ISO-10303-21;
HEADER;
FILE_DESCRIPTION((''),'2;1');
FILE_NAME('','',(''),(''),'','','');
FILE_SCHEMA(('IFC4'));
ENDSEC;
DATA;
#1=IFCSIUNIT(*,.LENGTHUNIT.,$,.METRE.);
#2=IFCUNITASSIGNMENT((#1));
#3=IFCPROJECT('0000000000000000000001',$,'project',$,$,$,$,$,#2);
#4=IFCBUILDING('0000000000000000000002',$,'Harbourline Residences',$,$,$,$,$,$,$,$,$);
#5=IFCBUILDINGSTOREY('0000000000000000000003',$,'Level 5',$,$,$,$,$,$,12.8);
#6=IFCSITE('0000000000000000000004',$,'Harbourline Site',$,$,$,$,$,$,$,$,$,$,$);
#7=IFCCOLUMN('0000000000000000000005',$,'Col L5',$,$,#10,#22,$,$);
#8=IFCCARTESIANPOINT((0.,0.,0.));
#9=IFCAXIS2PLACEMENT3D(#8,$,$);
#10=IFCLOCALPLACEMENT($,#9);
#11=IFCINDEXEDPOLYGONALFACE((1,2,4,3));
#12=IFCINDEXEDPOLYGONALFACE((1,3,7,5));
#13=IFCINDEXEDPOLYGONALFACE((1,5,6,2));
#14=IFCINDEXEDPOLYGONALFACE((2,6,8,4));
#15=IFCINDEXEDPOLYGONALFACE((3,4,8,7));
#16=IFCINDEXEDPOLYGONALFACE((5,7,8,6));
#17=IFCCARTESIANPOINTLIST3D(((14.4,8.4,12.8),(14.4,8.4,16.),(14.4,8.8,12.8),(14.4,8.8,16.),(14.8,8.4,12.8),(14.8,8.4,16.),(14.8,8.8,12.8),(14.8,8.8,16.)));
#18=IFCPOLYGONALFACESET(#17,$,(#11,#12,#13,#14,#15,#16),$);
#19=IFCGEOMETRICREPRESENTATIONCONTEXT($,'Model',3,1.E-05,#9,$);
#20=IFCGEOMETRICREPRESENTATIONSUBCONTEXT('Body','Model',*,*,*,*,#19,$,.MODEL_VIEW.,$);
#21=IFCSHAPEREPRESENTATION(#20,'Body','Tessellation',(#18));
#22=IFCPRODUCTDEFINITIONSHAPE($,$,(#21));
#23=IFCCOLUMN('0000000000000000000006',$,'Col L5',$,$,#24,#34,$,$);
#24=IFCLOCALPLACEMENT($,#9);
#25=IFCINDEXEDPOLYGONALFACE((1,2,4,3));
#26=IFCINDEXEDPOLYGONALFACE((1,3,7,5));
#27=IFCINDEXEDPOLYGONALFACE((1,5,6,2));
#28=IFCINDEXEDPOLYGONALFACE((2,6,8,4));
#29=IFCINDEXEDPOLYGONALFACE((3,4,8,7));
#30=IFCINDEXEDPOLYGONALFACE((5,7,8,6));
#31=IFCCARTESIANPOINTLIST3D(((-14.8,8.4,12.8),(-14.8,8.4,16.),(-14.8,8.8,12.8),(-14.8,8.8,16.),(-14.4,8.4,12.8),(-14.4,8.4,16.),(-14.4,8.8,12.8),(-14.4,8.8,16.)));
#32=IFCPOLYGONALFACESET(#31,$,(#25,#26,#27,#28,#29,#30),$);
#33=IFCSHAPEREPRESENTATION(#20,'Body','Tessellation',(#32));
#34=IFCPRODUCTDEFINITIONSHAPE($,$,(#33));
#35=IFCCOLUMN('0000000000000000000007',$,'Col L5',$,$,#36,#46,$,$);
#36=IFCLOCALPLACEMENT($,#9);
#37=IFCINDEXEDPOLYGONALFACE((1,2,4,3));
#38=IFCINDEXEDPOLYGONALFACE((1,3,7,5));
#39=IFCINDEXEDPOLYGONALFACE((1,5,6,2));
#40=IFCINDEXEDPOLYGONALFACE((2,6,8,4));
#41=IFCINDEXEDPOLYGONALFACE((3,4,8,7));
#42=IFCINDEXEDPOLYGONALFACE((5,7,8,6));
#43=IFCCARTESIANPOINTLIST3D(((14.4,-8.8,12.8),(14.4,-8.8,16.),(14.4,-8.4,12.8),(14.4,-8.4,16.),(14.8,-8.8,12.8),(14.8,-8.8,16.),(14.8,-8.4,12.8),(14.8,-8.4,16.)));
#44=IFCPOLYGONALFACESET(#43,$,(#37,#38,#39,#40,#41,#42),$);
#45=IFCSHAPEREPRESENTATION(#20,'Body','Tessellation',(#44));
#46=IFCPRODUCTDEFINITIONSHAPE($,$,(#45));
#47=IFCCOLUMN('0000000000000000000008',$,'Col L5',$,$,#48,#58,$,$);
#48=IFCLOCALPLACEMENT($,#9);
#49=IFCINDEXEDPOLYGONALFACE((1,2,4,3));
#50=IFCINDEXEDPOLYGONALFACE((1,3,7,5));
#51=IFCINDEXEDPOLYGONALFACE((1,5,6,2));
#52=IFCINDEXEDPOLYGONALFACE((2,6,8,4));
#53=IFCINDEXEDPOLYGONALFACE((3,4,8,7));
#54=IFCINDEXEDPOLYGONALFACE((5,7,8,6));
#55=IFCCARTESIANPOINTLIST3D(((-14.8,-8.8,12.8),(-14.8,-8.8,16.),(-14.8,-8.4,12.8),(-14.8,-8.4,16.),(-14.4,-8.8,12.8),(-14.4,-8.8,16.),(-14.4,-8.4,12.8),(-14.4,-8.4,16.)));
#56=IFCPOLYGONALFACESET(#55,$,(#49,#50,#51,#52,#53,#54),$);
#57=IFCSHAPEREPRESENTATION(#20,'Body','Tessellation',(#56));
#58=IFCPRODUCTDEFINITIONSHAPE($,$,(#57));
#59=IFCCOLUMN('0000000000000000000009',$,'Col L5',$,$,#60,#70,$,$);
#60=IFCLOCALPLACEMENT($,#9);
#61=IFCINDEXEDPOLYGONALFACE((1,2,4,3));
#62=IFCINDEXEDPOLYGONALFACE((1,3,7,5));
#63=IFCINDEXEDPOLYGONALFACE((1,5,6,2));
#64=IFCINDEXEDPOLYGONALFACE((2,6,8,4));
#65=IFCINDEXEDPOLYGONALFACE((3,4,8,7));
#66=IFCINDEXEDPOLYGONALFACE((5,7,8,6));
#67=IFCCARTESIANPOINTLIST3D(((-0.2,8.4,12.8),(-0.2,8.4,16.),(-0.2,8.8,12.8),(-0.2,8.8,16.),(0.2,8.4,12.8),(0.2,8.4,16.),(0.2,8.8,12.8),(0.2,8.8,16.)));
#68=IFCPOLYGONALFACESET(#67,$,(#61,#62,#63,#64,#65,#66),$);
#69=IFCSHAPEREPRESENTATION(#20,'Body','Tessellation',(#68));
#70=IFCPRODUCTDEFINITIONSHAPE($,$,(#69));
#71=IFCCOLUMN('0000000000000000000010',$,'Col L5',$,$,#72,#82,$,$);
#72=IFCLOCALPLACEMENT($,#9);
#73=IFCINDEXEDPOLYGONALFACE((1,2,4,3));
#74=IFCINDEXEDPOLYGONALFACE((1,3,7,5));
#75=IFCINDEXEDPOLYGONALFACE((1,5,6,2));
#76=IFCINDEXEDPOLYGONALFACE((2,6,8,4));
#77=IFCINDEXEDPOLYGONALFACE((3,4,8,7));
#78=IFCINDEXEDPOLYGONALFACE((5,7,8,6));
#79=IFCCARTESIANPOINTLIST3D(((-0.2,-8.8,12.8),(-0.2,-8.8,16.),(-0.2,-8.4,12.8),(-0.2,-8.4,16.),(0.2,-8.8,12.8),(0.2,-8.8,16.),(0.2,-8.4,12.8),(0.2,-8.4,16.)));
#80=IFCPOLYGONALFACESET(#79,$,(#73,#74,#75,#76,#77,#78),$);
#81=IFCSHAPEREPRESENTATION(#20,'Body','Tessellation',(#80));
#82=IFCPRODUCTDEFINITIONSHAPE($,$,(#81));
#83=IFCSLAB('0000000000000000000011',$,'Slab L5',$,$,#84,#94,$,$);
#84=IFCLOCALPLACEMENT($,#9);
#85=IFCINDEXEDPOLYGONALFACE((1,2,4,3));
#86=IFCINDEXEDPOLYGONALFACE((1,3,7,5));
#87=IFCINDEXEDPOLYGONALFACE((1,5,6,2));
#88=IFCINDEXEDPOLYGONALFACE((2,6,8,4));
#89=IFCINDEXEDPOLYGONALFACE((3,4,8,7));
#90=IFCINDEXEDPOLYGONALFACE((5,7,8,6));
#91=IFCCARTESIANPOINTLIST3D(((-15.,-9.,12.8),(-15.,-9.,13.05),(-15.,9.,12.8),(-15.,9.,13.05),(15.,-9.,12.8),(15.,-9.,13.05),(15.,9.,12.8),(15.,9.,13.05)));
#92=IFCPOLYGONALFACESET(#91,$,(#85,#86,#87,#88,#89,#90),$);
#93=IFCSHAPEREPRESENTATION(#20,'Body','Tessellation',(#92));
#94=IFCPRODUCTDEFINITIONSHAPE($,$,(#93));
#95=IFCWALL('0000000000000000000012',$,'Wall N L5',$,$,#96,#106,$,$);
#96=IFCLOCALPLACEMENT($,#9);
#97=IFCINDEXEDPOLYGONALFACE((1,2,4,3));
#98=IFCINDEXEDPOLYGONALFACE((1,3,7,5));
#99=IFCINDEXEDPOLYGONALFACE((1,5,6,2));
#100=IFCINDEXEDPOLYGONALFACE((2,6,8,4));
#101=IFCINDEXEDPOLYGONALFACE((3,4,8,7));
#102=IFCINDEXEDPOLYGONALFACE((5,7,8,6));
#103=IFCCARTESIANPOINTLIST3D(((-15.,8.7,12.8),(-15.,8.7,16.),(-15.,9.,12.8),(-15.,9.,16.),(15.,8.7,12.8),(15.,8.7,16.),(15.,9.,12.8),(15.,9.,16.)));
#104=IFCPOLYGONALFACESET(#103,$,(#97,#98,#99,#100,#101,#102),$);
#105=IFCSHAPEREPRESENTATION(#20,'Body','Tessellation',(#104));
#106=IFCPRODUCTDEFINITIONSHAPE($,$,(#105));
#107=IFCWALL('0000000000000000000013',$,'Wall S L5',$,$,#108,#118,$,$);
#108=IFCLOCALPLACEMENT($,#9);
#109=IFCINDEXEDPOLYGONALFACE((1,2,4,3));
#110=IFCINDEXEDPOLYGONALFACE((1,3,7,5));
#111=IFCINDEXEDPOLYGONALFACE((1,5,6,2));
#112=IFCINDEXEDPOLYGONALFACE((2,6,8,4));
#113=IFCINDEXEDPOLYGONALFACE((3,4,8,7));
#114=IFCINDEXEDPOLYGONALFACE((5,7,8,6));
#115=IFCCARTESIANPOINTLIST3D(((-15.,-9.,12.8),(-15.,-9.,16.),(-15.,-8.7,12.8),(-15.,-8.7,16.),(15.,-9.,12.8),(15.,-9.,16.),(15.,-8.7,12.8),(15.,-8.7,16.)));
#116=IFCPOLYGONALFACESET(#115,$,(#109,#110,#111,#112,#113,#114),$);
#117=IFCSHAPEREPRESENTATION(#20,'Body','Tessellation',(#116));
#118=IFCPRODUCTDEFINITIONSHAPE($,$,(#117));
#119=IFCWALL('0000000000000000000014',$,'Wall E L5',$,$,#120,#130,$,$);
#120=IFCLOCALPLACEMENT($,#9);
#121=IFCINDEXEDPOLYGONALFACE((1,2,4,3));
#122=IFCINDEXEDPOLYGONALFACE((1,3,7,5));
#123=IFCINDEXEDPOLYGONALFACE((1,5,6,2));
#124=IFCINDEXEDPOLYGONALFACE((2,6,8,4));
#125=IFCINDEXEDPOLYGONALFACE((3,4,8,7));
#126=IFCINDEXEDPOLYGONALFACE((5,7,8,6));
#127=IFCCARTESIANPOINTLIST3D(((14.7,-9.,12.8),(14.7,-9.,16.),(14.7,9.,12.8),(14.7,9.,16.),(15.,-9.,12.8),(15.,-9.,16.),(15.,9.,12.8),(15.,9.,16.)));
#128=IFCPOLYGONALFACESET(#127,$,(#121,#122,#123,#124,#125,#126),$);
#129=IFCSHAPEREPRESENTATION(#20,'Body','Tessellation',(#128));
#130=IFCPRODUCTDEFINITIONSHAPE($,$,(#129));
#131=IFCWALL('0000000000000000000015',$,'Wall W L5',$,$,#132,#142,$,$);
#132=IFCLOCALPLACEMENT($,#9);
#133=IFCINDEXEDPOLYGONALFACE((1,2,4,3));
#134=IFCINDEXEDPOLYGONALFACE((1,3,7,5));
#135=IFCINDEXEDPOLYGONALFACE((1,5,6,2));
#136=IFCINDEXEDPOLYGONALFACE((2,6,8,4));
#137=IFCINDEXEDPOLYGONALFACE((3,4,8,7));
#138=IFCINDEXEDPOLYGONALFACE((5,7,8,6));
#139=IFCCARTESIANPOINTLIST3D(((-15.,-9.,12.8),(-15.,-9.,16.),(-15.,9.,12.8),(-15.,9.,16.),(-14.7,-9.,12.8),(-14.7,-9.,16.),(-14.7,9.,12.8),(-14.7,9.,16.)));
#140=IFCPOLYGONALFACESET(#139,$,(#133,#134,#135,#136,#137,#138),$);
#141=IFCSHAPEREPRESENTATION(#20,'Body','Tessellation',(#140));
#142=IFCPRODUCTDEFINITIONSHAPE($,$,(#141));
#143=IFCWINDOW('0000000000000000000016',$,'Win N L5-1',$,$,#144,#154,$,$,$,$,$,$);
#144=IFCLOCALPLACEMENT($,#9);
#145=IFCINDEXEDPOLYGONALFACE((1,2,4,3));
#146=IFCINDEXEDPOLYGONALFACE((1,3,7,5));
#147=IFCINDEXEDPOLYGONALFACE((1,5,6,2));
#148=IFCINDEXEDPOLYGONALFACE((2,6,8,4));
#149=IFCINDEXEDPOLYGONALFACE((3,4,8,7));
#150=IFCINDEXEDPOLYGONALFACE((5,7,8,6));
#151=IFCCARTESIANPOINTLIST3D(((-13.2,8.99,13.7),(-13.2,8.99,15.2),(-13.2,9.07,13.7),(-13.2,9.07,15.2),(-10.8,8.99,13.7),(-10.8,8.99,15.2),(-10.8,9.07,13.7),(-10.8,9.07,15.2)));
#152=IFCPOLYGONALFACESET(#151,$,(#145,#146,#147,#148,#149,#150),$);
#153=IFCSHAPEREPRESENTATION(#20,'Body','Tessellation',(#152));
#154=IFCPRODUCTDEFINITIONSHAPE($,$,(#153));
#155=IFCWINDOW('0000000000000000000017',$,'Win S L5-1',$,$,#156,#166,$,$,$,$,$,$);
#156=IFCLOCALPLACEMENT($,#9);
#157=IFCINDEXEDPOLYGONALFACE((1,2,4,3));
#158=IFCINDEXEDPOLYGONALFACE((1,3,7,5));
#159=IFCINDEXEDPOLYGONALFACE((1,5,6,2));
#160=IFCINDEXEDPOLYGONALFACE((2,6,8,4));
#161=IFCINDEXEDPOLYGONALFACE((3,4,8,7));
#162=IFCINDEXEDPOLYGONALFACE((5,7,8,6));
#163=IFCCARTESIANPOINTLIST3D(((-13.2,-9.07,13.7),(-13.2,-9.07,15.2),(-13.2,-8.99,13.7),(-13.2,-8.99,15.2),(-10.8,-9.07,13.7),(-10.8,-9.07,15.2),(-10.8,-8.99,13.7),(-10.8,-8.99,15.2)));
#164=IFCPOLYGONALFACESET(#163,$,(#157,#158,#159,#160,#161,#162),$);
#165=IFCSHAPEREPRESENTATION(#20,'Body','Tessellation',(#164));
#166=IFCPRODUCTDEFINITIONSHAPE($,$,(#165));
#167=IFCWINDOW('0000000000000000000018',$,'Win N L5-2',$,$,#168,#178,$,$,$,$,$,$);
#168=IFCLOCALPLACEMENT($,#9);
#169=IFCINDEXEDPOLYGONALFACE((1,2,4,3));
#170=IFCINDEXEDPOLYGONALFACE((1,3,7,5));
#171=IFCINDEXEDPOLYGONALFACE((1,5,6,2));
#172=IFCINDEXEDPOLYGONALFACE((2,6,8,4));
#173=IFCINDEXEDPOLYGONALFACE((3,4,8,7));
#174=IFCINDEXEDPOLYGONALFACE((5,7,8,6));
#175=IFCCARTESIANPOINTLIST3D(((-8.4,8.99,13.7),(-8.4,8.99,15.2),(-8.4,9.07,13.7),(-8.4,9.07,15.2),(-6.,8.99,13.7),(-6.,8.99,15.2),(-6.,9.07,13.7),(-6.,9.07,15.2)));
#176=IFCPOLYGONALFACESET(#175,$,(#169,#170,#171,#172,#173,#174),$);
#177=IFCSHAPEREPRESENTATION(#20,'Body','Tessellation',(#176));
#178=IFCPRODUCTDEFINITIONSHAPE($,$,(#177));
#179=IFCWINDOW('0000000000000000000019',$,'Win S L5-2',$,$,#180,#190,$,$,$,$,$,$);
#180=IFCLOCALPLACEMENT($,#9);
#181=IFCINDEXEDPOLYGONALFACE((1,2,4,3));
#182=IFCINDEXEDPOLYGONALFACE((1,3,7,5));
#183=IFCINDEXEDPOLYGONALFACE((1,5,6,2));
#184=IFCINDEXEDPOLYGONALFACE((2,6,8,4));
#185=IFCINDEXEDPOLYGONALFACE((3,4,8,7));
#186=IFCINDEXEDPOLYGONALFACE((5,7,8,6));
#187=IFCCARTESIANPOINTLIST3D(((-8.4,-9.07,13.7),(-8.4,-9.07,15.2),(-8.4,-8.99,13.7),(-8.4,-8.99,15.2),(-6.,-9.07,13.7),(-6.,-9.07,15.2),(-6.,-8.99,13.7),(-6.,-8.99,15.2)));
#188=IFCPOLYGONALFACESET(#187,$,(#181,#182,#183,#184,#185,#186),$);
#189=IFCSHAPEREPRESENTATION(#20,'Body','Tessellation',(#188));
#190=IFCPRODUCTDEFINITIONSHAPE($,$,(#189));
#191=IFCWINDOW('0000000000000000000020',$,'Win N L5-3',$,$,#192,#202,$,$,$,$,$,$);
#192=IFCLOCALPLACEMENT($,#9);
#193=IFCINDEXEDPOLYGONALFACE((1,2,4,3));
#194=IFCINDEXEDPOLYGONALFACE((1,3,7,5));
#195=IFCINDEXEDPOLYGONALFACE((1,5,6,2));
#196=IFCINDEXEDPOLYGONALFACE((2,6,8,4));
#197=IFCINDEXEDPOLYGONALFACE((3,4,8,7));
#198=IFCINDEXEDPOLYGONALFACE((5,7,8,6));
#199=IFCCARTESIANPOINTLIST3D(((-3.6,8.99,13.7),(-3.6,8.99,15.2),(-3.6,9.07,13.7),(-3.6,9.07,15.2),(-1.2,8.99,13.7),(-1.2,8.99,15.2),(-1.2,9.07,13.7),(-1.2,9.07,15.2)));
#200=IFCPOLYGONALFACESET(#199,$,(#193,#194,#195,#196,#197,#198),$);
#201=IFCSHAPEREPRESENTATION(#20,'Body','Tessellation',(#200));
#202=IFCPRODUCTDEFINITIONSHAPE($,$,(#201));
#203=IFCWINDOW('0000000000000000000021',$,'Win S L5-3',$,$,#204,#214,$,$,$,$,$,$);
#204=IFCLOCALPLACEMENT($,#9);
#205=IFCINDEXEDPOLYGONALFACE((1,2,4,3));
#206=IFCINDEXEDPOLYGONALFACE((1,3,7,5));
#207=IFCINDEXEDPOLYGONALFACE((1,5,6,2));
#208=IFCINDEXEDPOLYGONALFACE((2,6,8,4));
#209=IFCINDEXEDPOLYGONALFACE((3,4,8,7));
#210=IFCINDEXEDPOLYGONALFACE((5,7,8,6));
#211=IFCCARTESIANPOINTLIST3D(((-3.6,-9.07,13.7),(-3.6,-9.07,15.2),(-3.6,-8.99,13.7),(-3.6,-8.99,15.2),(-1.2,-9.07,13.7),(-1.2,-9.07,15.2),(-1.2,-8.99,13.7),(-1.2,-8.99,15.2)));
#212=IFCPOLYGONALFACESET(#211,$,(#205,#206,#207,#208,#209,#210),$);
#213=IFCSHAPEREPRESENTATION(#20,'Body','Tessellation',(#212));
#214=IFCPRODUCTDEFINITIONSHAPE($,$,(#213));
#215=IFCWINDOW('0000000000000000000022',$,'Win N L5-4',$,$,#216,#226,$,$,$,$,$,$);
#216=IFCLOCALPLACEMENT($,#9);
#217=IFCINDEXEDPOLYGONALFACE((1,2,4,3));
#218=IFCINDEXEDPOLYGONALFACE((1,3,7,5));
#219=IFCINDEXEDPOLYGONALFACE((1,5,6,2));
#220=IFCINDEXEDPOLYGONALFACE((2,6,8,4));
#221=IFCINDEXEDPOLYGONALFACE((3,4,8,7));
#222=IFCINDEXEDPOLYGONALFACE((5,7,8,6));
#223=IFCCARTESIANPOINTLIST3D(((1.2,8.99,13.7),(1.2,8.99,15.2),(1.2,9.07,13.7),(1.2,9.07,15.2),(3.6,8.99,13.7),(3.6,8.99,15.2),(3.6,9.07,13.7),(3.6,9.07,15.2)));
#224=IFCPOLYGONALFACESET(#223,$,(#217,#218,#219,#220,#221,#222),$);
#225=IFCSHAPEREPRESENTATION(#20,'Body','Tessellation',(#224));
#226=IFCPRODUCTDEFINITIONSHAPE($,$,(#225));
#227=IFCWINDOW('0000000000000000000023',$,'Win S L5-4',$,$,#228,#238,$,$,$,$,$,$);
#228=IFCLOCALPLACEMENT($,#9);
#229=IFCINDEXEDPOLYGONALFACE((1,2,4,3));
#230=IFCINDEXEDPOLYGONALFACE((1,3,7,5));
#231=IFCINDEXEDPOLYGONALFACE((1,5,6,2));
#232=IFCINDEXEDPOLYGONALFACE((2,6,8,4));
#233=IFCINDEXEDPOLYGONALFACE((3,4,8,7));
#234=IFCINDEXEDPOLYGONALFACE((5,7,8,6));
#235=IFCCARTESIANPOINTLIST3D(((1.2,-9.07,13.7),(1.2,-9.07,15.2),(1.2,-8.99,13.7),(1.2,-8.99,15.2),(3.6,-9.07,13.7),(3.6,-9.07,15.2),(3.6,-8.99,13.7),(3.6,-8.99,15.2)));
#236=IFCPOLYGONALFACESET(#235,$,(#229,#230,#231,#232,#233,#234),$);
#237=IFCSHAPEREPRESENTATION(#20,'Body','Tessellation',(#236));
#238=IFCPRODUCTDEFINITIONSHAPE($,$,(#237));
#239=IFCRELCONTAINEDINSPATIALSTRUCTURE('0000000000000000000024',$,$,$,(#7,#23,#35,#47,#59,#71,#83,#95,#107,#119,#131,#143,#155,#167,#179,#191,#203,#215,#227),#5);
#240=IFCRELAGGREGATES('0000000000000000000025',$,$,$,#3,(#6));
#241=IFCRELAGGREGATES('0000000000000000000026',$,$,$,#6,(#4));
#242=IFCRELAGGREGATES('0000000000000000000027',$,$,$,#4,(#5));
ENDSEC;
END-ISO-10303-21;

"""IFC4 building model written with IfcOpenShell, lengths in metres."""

from ifc_helpers import new_model, si_unit, frame, frame_2d, origin, origin_2d, context, subcontext, project, spatial, rectangle, extrude, element, save


model = new_model("IFC4")

# Units and contexts
model_context = context("Model", 3, precision=1e-05, world=origin())
body_context = subcontext(model_context, "Body", "Model", "MODEL_VIEW")
ifc_project = project(units=[si_unit("LENGTHUNIT", "METRE")])

# Site, building, storey
site = spatial("IfcSite", under=ifc_project, Name="Harbourline Site")
building = spatial("IfcBuilding", under=site, Name="Harbourline Residences")
storey = spatial("IfcBuildingStorey", under=building, Name="Level 5", Elevation=12.8)

# Columns
element("IfcColumn", 1, inside=storey, Name="Col L5", context=body_context, shape_type="SweptSolid", body=[
    extrude(rectangle(XDim=0.4, YDim=0.4, at=frame_2d((14.6, 8.6))), frame((0.0, 0.0, 12.8)), (0.0, 0.0, 1.0), 3.2),
])
element("IfcColumn", 2, inside=storey, Name="Col L5", context=body_context, shape_type="SweptSolid", body=[
    extrude(rectangle(XDim=0.4, YDim=0.4, at=frame_2d((-14.6, 8.6))), frame((0.0, 0.0, 12.8)), (0.0, 0.0, 1.0), 3.2),
])
element("IfcColumn", 3, inside=storey, Name="Col L5", context=body_context, shape_type="SweptSolid", body=[
    extrude(rectangle(XDim=0.4, YDim=0.4, at=frame_2d((14.6, -8.6))), frame((0.0, 0.0, 12.8)), (0.0, 0.0, 1.0), 3.2),
])
element("IfcColumn", 4, inside=storey, Name="Col L5", context=body_context, shape_type="SweptSolid", body=[
    extrude(rectangle(XDim=0.4, YDim=0.4, at=frame_2d((-14.6, -8.6))), frame((0.0, 0.0, 12.8)), (0.0, 0.0, 1.0), 3.2),
])
element("IfcColumn", 5, inside=storey, Name="Col L5", context=body_context, shape_type="SweptSolid", body=[
    extrude(rectangle(XDim=0.4, YDim=0.4, at=frame_2d((0.0, 8.6))), frame((0.0, 0.0, 12.8)), (0.0, 0.0, 1.0), 3.2),
])
element("IfcColumn", 6, inside=storey, Name="Col L5", context=body_context, shape_type="SweptSolid", body=[
    extrude(rectangle(XDim=0.4, YDim=0.4, at=frame_2d((0.0, -8.6))), frame((0.0, 0.0, 12.8)), (0.0, 0.0, 1.0), 3.2),
])

# Slab
element("IfcSlab", 7, inside=storey, Name="Slab L5", context=body_context, shape_type="SweptSolid", body=[
    extrude(rectangle(XDim=30.0, YDim=18.0, at=origin_2d()), frame((0.0, 0.0, 12.8)), (0.0, 0.0, 1.0), 0.25),
])

# Walls
element("IfcWall", 8, inside=storey, Name="Wall N L5", context=body_context, shape_type="SweptSolid", body=[
    extrude(rectangle(XDim=30.0, YDim=0.3, at=frame_2d((0.0, 8.85))), frame((0.0, 0.0, 12.8)), (0.0, 0.0, 1.0), 3.2),
])
element("IfcWall", 9, inside=storey, Name="Wall S L5", context=body_context, shape_type="SweptSolid", body=[
    extrude(rectangle(XDim=30.0, YDim=0.3, at=frame_2d((0.0, -8.85))), frame((0.0, 0.0, 12.8)), (0.0, 0.0, 1.0), 3.2),
])
element("IfcWall", 10, inside=storey, Name="Wall E L5", context=body_context, shape_type="SweptSolid", body=[
    extrude(rectangle(XDim=0.3, YDim=18.0, at=frame_2d((14.85, 0.0))), frame((0.0, 0.0, 12.8)), (0.0, 0.0, 1.0), 3.2),
])
element("IfcWall", 11, inside=storey, Name="Wall W L5", context=body_context, shape_type="SweptSolid", body=[
    extrude(rectangle(XDim=0.3, YDim=18.0, at=frame_2d((-14.85, 0.0))), frame((0.0, 0.0, 12.8)), (0.0, 0.0, 1.0), 3.2),
])

# Windows
element("IfcWindow", 12, inside=storey, Name="Win N L5-1", context=body_context, shape_type="SweptSolid", body=[
    extrude(rectangle(XDim=2.4, YDim=0.08, at=frame_2d((-12.0, 9.03))), frame((0.0, 0.0, 13.7)), (0.0, 0.0, 1.0), 1.5),
])
element("IfcWindow", 13, inside=storey, Name="Win S L5-1", context=body_context, shape_type="SweptSolid", body=[
    extrude(rectangle(XDim=2.4, YDim=0.08, at=frame_2d((-12.0, -9.03))), frame((0.0, 0.0, 13.7)), (0.0, 0.0, 1.0), 1.5),
])
element("IfcWindow", 14, inside=storey, Name="Win N L5-2", context=body_context, shape_type="SweptSolid", body=[
    extrude(rectangle(XDim=2.4, YDim=0.08, at=frame_2d((-7.2, 9.03))), frame((0.0, 0.0, 13.7)), (0.0, 0.0, 1.0), 1.5),
])
element("IfcWindow", 15, inside=storey, Name="Win S L5-2", context=body_context, shape_type="SweptSolid", body=[
    extrude(rectangle(XDim=2.4, YDim=0.08, at=frame_2d((-7.2, -9.03))), frame((0.0, 0.0, 13.7)), (0.0, 0.0, 1.0), 1.5),
])
element("IfcWindow", 16, inside=storey, Name="Win N L5-3", context=body_context, shape_type="SweptSolid", body=[
    extrude(rectangle(XDim=2.4, YDim=0.08, at=frame_2d((-2.4, 9.03))), frame((0.0, 0.0, 13.7)), (0.0, 0.0, 1.0), 1.5),
])
element("IfcWindow", 17, inside=storey, Name="Win S L5-3", context=body_context, shape_type="SweptSolid", body=[
    extrude(rectangle(XDim=2.4, YDim=0.08, at=frame_2d((-2.4, -9.03))), frame((0.0, 0.0, 13.7)), (0.0, 0.0, 1.0), 1.5),
])
element("IfcWindow", 18, inside=storey, Name="Win N L5-4", context=body_context, shape_type="SweptSolid", body=[
    extrude(rectangle(XDim=2.4, YDim=0.08, at=frame_2d((2.4, 9.03))), frame((0.0, 0.0, 13.7)), (0.0, 0.0, 1.0), 1.5),
])
element("IfcWindow", 19, inside=storey, Name="Win S L5-4", context=body_context, shape_type="SweptSolid", body=[
    extrude(rectangle(XDim=2.4, YDim=0.08, at=frame_2d((2.4, -9.03))), frame((0.0, 0.0, 13.7)), (0.0, 0.0, 1.0), 1.5),
])

save(model, "model.ifc")
